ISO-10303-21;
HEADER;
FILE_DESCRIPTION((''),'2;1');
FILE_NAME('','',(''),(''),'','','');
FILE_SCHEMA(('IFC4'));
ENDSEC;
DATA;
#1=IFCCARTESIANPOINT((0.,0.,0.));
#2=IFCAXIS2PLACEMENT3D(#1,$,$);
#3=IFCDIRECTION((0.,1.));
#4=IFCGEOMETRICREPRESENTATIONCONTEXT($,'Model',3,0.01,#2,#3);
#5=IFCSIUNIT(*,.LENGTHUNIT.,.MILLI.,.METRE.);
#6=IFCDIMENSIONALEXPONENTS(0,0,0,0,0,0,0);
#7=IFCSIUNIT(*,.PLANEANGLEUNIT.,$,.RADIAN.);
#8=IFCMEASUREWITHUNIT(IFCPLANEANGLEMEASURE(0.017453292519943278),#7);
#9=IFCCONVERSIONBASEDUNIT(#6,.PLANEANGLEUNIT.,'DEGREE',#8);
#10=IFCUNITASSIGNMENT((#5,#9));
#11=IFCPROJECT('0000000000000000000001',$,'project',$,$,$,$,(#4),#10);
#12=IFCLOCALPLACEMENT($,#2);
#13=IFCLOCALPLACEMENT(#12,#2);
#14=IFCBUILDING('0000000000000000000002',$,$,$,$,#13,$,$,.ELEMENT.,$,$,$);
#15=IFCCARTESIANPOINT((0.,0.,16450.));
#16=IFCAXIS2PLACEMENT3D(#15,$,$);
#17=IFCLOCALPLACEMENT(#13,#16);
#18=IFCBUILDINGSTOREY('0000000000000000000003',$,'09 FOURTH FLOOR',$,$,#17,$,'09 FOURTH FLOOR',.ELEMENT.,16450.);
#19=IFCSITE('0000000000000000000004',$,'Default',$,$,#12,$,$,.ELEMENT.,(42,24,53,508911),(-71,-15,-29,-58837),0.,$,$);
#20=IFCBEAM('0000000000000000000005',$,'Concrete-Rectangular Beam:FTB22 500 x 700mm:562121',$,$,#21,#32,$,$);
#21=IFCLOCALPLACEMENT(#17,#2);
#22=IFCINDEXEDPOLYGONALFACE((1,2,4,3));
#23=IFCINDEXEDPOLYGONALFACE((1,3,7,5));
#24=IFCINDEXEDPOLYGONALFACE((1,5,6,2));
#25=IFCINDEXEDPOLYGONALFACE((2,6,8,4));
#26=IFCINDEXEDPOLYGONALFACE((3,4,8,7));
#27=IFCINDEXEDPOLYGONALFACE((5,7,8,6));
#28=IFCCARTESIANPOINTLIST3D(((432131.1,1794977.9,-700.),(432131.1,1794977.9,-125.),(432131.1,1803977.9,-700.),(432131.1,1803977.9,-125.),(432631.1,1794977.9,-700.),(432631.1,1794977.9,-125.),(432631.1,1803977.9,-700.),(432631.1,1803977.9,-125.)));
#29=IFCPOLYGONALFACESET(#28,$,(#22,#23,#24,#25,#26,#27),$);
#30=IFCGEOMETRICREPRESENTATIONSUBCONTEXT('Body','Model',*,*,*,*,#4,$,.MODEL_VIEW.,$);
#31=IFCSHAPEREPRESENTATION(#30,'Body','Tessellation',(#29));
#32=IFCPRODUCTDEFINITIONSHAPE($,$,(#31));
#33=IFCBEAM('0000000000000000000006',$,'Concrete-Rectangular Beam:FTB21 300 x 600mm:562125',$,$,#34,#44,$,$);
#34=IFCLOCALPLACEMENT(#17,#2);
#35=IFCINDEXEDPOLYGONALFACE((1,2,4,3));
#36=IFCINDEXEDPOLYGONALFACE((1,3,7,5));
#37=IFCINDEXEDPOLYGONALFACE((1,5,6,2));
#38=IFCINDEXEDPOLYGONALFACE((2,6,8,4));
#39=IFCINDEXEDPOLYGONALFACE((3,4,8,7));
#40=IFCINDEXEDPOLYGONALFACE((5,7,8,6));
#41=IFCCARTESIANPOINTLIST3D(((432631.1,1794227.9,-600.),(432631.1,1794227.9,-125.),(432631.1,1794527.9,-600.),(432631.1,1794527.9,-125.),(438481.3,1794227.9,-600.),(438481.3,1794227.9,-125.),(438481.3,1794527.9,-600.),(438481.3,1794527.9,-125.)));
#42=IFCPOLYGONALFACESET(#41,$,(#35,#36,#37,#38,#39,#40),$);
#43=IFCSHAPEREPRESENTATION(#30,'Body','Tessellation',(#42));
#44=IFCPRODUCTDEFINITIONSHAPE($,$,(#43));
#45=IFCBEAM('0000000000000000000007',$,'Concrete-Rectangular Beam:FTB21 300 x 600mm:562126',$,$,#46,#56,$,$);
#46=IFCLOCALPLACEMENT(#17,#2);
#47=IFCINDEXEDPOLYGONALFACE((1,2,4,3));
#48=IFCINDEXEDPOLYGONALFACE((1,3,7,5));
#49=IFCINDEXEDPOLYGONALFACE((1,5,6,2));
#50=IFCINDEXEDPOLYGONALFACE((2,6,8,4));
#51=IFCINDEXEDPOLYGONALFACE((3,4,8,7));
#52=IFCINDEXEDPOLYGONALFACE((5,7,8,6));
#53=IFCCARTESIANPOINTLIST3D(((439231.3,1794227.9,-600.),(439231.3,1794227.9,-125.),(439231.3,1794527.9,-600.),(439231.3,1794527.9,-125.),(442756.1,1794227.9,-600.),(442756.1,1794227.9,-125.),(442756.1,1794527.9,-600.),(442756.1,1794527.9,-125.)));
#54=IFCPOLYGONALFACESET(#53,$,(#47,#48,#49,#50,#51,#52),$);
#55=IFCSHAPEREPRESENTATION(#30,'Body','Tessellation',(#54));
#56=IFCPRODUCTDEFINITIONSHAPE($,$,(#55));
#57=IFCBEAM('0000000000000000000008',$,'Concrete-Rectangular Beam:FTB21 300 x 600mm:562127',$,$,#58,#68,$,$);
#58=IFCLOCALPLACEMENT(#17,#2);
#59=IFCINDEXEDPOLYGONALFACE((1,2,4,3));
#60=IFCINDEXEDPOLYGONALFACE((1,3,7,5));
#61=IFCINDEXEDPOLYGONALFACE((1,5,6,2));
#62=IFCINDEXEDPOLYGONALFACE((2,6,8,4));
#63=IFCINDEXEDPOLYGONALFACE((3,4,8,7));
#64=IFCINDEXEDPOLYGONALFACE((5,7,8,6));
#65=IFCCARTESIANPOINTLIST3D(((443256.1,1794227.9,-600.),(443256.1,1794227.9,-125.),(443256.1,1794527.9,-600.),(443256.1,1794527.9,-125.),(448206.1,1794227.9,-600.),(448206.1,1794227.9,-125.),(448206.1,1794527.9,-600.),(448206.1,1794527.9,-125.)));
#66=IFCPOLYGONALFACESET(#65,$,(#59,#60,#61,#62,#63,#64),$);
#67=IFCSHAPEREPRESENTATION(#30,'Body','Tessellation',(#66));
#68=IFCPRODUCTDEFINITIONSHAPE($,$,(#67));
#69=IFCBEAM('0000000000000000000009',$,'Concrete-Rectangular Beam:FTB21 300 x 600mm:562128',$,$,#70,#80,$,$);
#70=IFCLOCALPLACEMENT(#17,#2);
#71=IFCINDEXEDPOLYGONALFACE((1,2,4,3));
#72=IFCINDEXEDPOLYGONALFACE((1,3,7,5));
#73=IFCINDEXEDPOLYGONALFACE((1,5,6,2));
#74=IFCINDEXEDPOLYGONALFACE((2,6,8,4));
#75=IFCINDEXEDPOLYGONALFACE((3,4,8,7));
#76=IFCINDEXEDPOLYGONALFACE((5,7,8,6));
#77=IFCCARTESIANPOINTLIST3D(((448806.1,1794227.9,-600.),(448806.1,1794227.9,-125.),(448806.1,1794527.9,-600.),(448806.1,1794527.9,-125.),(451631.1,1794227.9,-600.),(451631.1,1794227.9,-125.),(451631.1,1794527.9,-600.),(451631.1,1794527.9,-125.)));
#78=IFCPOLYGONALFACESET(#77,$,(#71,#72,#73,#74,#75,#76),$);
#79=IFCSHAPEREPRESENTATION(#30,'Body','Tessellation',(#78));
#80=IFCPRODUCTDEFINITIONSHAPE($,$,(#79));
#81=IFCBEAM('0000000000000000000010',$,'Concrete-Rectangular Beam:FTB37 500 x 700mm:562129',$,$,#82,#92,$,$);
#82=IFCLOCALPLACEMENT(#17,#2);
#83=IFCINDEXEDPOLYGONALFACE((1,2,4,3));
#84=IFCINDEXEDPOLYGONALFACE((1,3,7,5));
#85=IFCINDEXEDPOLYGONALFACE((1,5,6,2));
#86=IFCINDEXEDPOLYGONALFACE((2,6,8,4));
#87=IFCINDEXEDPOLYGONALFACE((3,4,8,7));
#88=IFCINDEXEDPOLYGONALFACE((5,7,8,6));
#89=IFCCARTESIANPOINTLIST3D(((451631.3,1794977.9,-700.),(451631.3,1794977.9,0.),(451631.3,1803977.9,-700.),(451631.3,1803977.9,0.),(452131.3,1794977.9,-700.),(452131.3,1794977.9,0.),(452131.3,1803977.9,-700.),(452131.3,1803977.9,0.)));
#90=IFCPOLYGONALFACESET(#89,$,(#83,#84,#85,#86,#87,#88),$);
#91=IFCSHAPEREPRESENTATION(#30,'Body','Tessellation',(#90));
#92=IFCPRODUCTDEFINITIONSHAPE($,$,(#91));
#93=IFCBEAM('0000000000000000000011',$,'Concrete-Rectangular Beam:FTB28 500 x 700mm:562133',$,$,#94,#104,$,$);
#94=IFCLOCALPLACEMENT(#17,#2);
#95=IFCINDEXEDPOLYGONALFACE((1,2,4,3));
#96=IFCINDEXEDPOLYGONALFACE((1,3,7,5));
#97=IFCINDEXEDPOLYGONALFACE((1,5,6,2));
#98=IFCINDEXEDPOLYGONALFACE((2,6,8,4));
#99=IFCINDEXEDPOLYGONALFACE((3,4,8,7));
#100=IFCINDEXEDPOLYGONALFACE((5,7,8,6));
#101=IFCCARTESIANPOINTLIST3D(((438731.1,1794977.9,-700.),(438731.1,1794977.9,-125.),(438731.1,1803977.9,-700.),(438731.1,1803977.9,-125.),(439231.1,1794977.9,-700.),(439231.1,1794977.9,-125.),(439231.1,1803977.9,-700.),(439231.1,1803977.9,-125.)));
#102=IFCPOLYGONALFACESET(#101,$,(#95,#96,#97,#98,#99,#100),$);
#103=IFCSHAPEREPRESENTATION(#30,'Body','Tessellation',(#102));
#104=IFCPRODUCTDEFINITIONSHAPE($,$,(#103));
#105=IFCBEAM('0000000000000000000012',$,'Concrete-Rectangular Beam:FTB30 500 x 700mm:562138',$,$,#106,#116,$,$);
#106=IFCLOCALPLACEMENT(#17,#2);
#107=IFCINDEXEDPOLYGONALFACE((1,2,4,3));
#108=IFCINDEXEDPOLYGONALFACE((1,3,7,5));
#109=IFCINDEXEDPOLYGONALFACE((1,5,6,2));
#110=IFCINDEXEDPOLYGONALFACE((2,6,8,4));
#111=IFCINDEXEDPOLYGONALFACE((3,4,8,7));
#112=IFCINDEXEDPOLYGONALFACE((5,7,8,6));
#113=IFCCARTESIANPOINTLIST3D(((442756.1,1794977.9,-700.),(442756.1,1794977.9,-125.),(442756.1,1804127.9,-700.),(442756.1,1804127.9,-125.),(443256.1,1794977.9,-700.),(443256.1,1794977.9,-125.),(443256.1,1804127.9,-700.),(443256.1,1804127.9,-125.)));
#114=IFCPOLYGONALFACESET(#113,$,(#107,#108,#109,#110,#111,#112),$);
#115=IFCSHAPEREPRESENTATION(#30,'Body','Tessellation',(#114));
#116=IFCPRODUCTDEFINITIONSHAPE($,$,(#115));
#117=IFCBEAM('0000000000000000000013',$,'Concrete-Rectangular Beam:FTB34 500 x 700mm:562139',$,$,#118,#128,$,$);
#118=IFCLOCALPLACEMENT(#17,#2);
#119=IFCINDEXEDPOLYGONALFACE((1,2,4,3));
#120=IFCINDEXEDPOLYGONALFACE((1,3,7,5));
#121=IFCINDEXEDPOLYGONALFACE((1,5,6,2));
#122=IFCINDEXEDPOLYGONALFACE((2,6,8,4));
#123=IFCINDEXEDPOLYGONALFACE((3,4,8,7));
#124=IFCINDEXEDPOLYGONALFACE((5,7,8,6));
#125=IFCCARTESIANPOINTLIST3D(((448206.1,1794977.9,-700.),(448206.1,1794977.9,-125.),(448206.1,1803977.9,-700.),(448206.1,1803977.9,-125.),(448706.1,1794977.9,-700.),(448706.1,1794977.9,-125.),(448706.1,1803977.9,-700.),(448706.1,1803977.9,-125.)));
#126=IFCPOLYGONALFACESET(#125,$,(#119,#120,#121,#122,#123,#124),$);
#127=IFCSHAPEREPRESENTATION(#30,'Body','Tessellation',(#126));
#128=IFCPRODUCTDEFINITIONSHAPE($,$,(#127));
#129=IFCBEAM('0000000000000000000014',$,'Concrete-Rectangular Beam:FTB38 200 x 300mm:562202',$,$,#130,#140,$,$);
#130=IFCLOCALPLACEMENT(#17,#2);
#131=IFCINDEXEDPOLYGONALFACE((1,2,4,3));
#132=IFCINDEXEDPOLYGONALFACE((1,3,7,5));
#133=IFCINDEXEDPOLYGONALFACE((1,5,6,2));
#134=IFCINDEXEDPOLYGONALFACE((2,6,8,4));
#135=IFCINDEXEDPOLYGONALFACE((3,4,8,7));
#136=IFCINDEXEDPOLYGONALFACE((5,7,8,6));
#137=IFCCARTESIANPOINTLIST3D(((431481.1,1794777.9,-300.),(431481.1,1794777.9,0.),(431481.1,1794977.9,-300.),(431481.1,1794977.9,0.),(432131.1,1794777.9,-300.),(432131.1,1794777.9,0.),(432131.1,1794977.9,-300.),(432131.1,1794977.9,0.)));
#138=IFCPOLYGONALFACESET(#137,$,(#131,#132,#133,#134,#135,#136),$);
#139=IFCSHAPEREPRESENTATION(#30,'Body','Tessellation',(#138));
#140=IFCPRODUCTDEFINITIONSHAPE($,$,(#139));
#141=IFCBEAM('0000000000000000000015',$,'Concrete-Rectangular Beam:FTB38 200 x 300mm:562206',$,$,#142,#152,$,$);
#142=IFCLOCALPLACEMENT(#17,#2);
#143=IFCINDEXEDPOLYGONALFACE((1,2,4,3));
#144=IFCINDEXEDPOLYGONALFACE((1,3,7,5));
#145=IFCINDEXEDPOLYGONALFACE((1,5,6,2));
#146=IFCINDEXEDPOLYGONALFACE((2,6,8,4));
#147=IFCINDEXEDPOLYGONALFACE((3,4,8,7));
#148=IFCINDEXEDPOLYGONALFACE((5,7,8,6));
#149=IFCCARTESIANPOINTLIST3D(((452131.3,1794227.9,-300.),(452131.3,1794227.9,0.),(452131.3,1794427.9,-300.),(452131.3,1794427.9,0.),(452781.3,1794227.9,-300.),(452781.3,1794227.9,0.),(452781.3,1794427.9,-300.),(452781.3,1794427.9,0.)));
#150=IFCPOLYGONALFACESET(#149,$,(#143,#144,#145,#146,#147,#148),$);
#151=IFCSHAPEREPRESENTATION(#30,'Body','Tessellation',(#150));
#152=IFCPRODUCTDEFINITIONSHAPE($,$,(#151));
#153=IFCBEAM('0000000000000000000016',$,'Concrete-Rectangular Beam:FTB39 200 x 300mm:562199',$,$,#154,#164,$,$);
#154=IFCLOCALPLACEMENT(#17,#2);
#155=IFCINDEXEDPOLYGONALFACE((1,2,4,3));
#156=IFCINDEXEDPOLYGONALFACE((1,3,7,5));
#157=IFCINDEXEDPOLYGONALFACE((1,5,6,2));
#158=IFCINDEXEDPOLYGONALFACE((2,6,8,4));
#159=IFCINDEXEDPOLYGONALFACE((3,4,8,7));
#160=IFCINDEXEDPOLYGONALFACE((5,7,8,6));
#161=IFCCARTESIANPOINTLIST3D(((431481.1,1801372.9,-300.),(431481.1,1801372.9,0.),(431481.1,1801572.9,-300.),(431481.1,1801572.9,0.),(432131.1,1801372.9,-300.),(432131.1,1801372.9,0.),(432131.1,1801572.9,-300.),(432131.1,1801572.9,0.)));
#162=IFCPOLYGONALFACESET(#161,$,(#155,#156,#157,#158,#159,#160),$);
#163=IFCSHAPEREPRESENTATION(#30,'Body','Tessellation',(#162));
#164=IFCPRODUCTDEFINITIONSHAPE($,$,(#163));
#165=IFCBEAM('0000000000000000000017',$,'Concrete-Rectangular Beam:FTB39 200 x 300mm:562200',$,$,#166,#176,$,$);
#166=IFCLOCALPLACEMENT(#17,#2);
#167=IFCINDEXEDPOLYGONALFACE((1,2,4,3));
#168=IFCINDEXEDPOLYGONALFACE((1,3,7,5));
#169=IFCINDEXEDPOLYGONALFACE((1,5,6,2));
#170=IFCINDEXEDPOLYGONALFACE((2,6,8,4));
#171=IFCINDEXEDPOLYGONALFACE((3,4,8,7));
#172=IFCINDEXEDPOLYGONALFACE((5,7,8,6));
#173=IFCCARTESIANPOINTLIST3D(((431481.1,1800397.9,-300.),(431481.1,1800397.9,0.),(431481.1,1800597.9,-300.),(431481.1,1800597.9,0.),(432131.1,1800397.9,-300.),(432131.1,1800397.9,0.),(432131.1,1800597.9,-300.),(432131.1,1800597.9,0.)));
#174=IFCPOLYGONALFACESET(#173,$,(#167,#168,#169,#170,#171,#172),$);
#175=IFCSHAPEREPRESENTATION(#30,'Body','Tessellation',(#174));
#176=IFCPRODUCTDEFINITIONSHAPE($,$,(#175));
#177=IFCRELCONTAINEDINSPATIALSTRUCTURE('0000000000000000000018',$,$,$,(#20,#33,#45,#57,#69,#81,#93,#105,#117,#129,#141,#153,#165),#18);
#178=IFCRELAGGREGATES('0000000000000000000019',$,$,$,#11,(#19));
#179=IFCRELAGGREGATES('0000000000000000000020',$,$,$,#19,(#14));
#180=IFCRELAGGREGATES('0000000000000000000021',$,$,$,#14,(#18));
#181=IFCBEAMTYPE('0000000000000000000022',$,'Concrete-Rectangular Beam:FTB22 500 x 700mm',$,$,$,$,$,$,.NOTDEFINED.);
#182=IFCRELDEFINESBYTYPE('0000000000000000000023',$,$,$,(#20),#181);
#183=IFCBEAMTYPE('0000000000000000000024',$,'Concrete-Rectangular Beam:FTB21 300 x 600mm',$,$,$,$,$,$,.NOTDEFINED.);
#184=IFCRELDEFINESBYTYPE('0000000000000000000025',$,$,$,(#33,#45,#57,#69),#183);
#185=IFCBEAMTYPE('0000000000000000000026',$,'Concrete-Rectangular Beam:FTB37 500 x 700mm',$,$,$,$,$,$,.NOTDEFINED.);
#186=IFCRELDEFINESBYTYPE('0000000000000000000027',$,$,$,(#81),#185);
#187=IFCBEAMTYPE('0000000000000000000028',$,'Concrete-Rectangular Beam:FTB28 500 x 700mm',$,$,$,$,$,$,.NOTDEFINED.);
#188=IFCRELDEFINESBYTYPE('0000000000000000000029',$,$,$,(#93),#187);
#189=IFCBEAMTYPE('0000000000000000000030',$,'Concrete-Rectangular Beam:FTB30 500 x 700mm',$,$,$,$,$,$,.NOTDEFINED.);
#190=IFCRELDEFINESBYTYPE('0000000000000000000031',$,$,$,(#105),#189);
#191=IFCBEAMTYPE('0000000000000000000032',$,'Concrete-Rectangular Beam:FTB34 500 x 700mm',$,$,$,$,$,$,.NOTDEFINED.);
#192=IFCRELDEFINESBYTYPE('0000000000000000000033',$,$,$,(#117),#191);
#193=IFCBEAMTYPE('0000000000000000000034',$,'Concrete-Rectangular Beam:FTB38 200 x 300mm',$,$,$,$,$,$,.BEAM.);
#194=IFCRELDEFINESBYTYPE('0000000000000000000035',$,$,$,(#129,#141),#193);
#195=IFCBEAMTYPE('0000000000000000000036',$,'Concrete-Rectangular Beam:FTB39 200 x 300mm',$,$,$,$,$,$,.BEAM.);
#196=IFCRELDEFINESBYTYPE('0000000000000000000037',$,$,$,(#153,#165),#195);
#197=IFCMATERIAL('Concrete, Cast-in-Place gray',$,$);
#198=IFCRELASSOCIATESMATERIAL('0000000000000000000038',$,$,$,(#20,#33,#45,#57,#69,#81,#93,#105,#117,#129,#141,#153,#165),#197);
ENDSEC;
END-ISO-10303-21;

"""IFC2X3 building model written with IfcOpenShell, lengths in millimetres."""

from ifc_helpers import new_model, entity, si_unit, converted_unit, direction, frame, frame_2d, origin, place, context, subcontext, project, spatial, rectangle, extrude, material, type_object, element, save


model = new_model("IFC2X3")

# Units and contexts
model_context = context("Model", 3, precision=0.01, world=origin(), true_north=direction((0.0, 1.0)))
body_context = subcontext(model_context, "Body", "Model", "MODEL_VIEW")
ifc_project = project(units=[si_unit("LENGTHUNIT", "METRE", prefix="MILLI"), converted_unit("PLANEANGLEUNIT", "DEGREE", entity("IfcPlaneAngleMeasure", 0.017453292519943278), si_unit("PLANEANGLEUNIT", "RADIAN"), dimensions=[0, 0, 0, 0, 0, 0, 0])], contexts=[model_context])

# Site, building, storey
site_placement = place(None, origin())
site = spatial("IfcSite", under=ifc_project, at=site_placement, Name="Default", CompositionType="ELEMENT", RefLatitude=(42, 24, 53, 508911), RefLongitude=(-71, -15, -29, -58837), RefElevation=0.0)
building_placement = place(site_placement, origin())
building = spatial("IfcBuilding", under=site, at=building_placement, CompositionType="ELEMENT")
storey_placement = place(building_placement, frame((0.0, 0.0, 16450.0)))
storey = spatial("IfcBuildingStorey", under=building, at=storey_placement, Name="09 FOURTH FLOOR", LongName="09 FOURTH FLOOR", CompositionType="ELEMENT", Elevation=16450.0)

# Beams
ifc_material_1 = material(Name="Concrete, Cast-in-Place gray")
beam_type_1 = type_object("IfcBeamType", Name="Concrete-Rectangular Beam:FTB22 500 x 700mm", PredefinedType="NOTDEFINED")
beam_1_placement = place(storey_placement, frame((432631.1, 1794977.9, 0.0), z_axis=(0.0, 0.0, 1.0), x_axis=(0.0, 1.0, 0.0)))
element("IfcBeam", 1, at=beam_1_placement, inside=storey, type_object=beam_type_1, material=ifc_material_1, Name="Concrete-Rectangular Beam:FTB22 500 x 700mm:562121", context=body_context, shape_type="SweptSolid", body=[
    extrude(rectangle(XDim=575.0, YDim=500.0, at=frame_2d((0.0, 0.0), x_axis=(1.0, 0.0))), frame((0.0, 250.0, -412.5), z_axis=(1.0, 0.0, 0.0), x_axis=(0.0, 0.0, -1.0)), (0.0, 0.0, 1.0), 9000.0),
])
beam_type_2 = type_object("IfcBeamType", Name="Concrete-Rectangular Beam:FTB21 300 x 600mm", PredefinedType="NOTDEFINED")
beam_2_placement = place(storey_placement, frame((432631.1, 1794527.9, 0.0)))
element("IfcBeam", 2, at=beam_2_placement, inside=storey, type_object=beam_type_2, material=ifc_material_1, Name="Concrete-Rectangular Beam:FTB21 300 x 600mm:562125", context=body_context, shape_type="SweptSolid", body=[
    extrude(rectangle(XDim=475.0, YDim=300.0, at=frame_2d((0.0, 0.0), x_axis=(1.0, 0.0))), frame((0.0, -150.0, -362.5), z_axis=(1.0, 0.0, 0.0), x_axis=(0.0, 0.0, -1.0)), (0.0, 0.0, 1.0), 5850.2),
])
beam_3_placement = place(storey_placement, frame((439231.1, 1794527.9, 0.0)))
element("IfcBeam", 3, at=beam_3_placement, inside=storey, type_object=beam_type_2, material=ifc_material_1, Name="Concrete-Rectangular Beam:FTB21 300 x 600mm:562126", context=body_context, shape_type="SweptSolid", body=[
    extrude(rectangle(XDim=475.0, YDim=300.0, at=frame_2d((0.0, 0.0), x_axis=(1.0, 0.0))), frame((0.2, -150.0, -362.5), z_axis=(1.0, 0.0, 0.0), x_axis=(0.0, 0.0, -1.0)), (0.0, 0.0, 1.0), 3524.8),
])
beam_4_placement = place(storey_placement, frame((443256.1, 1794527.9, 0.0)))
element("IfcBeam", 4, at=beam_4_placement, inside=storey, type_object=beam_type_2, material=ifc_material_1, Name="Concrete-Rectangular Beam:FTB21 300 x 600mm:562127", context=body_context, shape_type="SweptSolid", body=[
    extrude(rectangle(XDim=475.0, YDim=300.0, at=frame_2d((0.0, 0.0), x_axis=(1.0, 0.0))), frame((0.0, -150.0, -362.5), z_axis=(1.0, 0.0, 0.0), x_axis=(0.0, 0.0, -1.0)), (0.0, 0.0, 1.0), 4950.0),
])
beam_5_placement = place(storey_placement, frame((448806.1, 1794527.9, 0.0)))
element("IfcBeam", 5, at=beam_5_placement, inside=storey, type_object=beam_type_2, material=ifc_material_1, Name="Concrete-Rectangular Beam:FTB21 300 x 600mm:562128", context=body_context, shape_type="SweptSolid", body=[
    extrude(rectangle(XDim=475.0, YDim=300.0, at=frame_2d((0.0, 0.0), x_axis=(1.0, 0.0))), frame((0.0, -150.0, -362.5), z_axis=(1.0, 0.0, 0.0), x_axis=(0.0, 0.0, -1.0)), (0.0, 0.0, 1.0), 2825.0),
])
beam_type_3 = type_object("IfcBeamType", Name="Concrete-Rectangular Beam:FTB37 500 x 700mm", PredefinedType="NOTDEFINED")
beam_6_placement = place(storey_placement, frame((451631.3, 1794977.9, 0.0), z_axis=(0.0, 0.0, 1.0), x_axis=(0.0, 1.0, 0.0)))
element("IfcBeam", 6, at=beam_6_placement, inside=storey, type_object=beam_type_3, material=ifc_material_1, Name="Concrete-Rectangular Beam:FTB37 500 x 700mm:562129", context=body_context, shape_type="SweptSolid", body=[
    extrude(rectangle(XDim=700.0, YDim=500.0, at=frame_2d((0.0, 0.0), x_axis=(1.0, 0.0))), frame((0.0, -250.0, -350.0), z_axis=(1.0, 0.0, 0.0), x_axis=(0.0, 0.0, -1.0)), (0.0, 0.0, 1.0), 9000.0),
])
beam_type_4 = type_object("IfcBeamType", Name="Concrete-Rectangular Beam:FTB28 500 x 700mm", PredefinedType="NOTDEFINED")
beam_7_placement = place(storey_placement, frame((438731.1, 1794977.9, 0.0), z_axis=(0.0, 0.0, 1.0), x_axis=(0.0, 1.0, 0.0)))
element("IfcBeam", 7, at=beam_7_placement, inside=storey, type_object=beam_type_4, material=ifc_material_1, Name="Concrete-Rectangular Beam:FTB28 500 x 700mm:562133", context=body_context, shape_type="SweptSolid", body=[
    extrude(rectangle(XDim=575.0, YDim=500.0, at=frame_2d((0.0, 0.0), x_axis=(1.0, 0.0))), frame((0.0, -250.0, -412.5), z_axis=(1.0, 0.0, 0.0), x_axis=(0.0, 0.0, -1.0)), (0.0, 0.0, 1.0), 9000.0),
])
beam_type_5 = type_object("IfcBeamType", Name="Concrete-Rectangular Beam:FTB30 500 x 700mm", PredefinedType="NOTDEFINED")
beam_8_placement = place(storey_placement, frame((442756.1, 1794977.5, 0.0), z_axis=(0.0, 0.0, 1.0), x_axis=(0.0, 1.0, 0.0)))
element("IfcBeam", 8, at=beam_8_placement, inside=storey, type_object=beam_type_5, material=ifc_material_1, Name="Concrete-Rectangular Beam:FTB30 500 x 700mm:562138", context=body_context, shape_type="SweptSolid", body=[
    extrude(rectangle(XDim=575.0, YDim=500.0, at=frame_2d((0.0, 0.0), x_axis=(1.0, 0.0))), frame((0.4, -250.0, -412.5), z_axis=(1.0, 0.0, 0.0), x_axis=(0.0, 0.0, -1.0)), (0.0, 0.0, 1.0), 9150.0),
])
beam_type_6 = type_object("IfcBeamType", Name="Concrete-Rectangular Beam:FTB34 500 x 700mm", PredefinedType="NOTDEFINED")
beam_9_placement = place(storey_placement, frame((448206.1, 1794977.9, 0.0), z_axis=(0.0, 0.0, 1.0), x_axis=(0.0, 1.0, 0.0)))
element("IfcBeam", 9, at=beam_9_placement, inside=storey, type_object=beam_type_6, material=ifc_material_1, Name="Concrete-Rectangular Beam:FTB34 500 x 700mm:562139", context=body_context, shape_type="SweptSolid", body=[
    extrude(rectangle(XDim=575.0, YDim=500.0, at=frame_2d((0.0, 0.0), x_axis=(1.0, 0.0))), frame((0.0, -250.0, -412.5), z_axis=(1.0, 0.0, 0.0), x_axis=(0.0, 0.0, -1.0)), (0.0, 0.0, 1.0), 9000.0),
])
beam_type_7 = type_object("IfcBeamType", Name="Concrete-Rectangular Beam:FTB38 200 x 300mm", PredefinedType="BEAM")
beam_10_placement = place(storey_placement, frame((431481.1, 1794777.9, 0.0)))
element("IfcBeam", 10, at=beam_10_placement, inside=storey, type_object=beam_type_7, material=ifc_material_1, Name="Concrete-Rectangular Beam:FTB38 200 x 300mm:562202", context=body_context, shape_type="SweptSolid", body=[
    extrude(rectangle(XDim=300.0, YDim=200.0, at=frame_2d((0.0, 0.0), x_axis=(1.0, 0.0))), frame((0.0, 100.0, -150.0), z_axis=(1.0, 0.0, 0.0), x_axis=(0.0, 0.0, -1.0)), (0.0, 0.0, 1.0), 650.0),
])
beam_11_placement = place(storey_placement, frame((452781.3, 1794227.9, 0.0), z_axis=(0.0, 0.0, 1.0), x_axis=(-1.0, 0.0, 0.0)))
element("IfcBeam", 11, at=beam_11_placement, inside=storey, type_object=beam_type_7, material=ifc_material_1, Name="Concrete-Rectangular Beam:FTB38 200 x 300mm:562206", context=body_context, shape_type="SweptSolid", body=[
    extrude(rectangle(XDim=300.0, YDim=200.0, at=frame_2d((0.0, 0.0), x_axis=(1.0, 0.0))), frame((0.0, -100.0, -150.0), z_axis=(1.0, 0.0, 0.0), x_axis=(0.0, 0.0, -1.0)), (0.0, 0.0, 1.0), 650.0),
])
beam_type_8 = type_object("IfcBeamType", Name="Concrete-Rectangular Beam:FTB39 200 x 300mm", PredefinedType="BEAM")
beam_12_placement = place(storey_placement, frame((431681.1, 1801372.9, 0.0)))
element("IfcBeam", 12, at=beam_12_placement, inside=storey, type_object=beam_type_8, material=ifc_material_1, Name="Concrete-Rectangular Beam:FTB39 200 x 300mm:562199", context=body_context, shape_type="SweptSolid", body=[
    extrude(rectangle(XDim=300.0, YDim=200.0, at=frame_2d((0.0, 0.0), x_axis=(1.0, 0.0))), frame((-200.0, 100.0, -150.0), z_axis=(1.0, 0.0, 0.0), x_axis=(0.0, 0.0, -1.0)), (0.0, 0.0, 1.0), 650.0),
])
beam_13_placement = place(storey_placement, frame((431681.1, 1800597.9, 0.0)))
element("IfcBeam", 13, at=beam_13_placement, inside=storey, type_object=beam_type_8, material=ifc_material_1, Name="Concrete-Rectangular Beam:FTB39 200 x 300mm:562200", context=body_context, shape_type="SweptSolid", body=[
    extrude(rectangle(XDim=300.0, YDim=200.0, at=frame_2d((0.0, 0.0), x_axis=(1.0, 0.0))), frame((-200.0, -100.0, -150.0), z_axis=(1.0, 0.0, 0.0), x_axis=(0.0, 0.0, -1.0)), (0.0, 0.0, 1.0), 650.0),
])

save(model, "model.ifc")
